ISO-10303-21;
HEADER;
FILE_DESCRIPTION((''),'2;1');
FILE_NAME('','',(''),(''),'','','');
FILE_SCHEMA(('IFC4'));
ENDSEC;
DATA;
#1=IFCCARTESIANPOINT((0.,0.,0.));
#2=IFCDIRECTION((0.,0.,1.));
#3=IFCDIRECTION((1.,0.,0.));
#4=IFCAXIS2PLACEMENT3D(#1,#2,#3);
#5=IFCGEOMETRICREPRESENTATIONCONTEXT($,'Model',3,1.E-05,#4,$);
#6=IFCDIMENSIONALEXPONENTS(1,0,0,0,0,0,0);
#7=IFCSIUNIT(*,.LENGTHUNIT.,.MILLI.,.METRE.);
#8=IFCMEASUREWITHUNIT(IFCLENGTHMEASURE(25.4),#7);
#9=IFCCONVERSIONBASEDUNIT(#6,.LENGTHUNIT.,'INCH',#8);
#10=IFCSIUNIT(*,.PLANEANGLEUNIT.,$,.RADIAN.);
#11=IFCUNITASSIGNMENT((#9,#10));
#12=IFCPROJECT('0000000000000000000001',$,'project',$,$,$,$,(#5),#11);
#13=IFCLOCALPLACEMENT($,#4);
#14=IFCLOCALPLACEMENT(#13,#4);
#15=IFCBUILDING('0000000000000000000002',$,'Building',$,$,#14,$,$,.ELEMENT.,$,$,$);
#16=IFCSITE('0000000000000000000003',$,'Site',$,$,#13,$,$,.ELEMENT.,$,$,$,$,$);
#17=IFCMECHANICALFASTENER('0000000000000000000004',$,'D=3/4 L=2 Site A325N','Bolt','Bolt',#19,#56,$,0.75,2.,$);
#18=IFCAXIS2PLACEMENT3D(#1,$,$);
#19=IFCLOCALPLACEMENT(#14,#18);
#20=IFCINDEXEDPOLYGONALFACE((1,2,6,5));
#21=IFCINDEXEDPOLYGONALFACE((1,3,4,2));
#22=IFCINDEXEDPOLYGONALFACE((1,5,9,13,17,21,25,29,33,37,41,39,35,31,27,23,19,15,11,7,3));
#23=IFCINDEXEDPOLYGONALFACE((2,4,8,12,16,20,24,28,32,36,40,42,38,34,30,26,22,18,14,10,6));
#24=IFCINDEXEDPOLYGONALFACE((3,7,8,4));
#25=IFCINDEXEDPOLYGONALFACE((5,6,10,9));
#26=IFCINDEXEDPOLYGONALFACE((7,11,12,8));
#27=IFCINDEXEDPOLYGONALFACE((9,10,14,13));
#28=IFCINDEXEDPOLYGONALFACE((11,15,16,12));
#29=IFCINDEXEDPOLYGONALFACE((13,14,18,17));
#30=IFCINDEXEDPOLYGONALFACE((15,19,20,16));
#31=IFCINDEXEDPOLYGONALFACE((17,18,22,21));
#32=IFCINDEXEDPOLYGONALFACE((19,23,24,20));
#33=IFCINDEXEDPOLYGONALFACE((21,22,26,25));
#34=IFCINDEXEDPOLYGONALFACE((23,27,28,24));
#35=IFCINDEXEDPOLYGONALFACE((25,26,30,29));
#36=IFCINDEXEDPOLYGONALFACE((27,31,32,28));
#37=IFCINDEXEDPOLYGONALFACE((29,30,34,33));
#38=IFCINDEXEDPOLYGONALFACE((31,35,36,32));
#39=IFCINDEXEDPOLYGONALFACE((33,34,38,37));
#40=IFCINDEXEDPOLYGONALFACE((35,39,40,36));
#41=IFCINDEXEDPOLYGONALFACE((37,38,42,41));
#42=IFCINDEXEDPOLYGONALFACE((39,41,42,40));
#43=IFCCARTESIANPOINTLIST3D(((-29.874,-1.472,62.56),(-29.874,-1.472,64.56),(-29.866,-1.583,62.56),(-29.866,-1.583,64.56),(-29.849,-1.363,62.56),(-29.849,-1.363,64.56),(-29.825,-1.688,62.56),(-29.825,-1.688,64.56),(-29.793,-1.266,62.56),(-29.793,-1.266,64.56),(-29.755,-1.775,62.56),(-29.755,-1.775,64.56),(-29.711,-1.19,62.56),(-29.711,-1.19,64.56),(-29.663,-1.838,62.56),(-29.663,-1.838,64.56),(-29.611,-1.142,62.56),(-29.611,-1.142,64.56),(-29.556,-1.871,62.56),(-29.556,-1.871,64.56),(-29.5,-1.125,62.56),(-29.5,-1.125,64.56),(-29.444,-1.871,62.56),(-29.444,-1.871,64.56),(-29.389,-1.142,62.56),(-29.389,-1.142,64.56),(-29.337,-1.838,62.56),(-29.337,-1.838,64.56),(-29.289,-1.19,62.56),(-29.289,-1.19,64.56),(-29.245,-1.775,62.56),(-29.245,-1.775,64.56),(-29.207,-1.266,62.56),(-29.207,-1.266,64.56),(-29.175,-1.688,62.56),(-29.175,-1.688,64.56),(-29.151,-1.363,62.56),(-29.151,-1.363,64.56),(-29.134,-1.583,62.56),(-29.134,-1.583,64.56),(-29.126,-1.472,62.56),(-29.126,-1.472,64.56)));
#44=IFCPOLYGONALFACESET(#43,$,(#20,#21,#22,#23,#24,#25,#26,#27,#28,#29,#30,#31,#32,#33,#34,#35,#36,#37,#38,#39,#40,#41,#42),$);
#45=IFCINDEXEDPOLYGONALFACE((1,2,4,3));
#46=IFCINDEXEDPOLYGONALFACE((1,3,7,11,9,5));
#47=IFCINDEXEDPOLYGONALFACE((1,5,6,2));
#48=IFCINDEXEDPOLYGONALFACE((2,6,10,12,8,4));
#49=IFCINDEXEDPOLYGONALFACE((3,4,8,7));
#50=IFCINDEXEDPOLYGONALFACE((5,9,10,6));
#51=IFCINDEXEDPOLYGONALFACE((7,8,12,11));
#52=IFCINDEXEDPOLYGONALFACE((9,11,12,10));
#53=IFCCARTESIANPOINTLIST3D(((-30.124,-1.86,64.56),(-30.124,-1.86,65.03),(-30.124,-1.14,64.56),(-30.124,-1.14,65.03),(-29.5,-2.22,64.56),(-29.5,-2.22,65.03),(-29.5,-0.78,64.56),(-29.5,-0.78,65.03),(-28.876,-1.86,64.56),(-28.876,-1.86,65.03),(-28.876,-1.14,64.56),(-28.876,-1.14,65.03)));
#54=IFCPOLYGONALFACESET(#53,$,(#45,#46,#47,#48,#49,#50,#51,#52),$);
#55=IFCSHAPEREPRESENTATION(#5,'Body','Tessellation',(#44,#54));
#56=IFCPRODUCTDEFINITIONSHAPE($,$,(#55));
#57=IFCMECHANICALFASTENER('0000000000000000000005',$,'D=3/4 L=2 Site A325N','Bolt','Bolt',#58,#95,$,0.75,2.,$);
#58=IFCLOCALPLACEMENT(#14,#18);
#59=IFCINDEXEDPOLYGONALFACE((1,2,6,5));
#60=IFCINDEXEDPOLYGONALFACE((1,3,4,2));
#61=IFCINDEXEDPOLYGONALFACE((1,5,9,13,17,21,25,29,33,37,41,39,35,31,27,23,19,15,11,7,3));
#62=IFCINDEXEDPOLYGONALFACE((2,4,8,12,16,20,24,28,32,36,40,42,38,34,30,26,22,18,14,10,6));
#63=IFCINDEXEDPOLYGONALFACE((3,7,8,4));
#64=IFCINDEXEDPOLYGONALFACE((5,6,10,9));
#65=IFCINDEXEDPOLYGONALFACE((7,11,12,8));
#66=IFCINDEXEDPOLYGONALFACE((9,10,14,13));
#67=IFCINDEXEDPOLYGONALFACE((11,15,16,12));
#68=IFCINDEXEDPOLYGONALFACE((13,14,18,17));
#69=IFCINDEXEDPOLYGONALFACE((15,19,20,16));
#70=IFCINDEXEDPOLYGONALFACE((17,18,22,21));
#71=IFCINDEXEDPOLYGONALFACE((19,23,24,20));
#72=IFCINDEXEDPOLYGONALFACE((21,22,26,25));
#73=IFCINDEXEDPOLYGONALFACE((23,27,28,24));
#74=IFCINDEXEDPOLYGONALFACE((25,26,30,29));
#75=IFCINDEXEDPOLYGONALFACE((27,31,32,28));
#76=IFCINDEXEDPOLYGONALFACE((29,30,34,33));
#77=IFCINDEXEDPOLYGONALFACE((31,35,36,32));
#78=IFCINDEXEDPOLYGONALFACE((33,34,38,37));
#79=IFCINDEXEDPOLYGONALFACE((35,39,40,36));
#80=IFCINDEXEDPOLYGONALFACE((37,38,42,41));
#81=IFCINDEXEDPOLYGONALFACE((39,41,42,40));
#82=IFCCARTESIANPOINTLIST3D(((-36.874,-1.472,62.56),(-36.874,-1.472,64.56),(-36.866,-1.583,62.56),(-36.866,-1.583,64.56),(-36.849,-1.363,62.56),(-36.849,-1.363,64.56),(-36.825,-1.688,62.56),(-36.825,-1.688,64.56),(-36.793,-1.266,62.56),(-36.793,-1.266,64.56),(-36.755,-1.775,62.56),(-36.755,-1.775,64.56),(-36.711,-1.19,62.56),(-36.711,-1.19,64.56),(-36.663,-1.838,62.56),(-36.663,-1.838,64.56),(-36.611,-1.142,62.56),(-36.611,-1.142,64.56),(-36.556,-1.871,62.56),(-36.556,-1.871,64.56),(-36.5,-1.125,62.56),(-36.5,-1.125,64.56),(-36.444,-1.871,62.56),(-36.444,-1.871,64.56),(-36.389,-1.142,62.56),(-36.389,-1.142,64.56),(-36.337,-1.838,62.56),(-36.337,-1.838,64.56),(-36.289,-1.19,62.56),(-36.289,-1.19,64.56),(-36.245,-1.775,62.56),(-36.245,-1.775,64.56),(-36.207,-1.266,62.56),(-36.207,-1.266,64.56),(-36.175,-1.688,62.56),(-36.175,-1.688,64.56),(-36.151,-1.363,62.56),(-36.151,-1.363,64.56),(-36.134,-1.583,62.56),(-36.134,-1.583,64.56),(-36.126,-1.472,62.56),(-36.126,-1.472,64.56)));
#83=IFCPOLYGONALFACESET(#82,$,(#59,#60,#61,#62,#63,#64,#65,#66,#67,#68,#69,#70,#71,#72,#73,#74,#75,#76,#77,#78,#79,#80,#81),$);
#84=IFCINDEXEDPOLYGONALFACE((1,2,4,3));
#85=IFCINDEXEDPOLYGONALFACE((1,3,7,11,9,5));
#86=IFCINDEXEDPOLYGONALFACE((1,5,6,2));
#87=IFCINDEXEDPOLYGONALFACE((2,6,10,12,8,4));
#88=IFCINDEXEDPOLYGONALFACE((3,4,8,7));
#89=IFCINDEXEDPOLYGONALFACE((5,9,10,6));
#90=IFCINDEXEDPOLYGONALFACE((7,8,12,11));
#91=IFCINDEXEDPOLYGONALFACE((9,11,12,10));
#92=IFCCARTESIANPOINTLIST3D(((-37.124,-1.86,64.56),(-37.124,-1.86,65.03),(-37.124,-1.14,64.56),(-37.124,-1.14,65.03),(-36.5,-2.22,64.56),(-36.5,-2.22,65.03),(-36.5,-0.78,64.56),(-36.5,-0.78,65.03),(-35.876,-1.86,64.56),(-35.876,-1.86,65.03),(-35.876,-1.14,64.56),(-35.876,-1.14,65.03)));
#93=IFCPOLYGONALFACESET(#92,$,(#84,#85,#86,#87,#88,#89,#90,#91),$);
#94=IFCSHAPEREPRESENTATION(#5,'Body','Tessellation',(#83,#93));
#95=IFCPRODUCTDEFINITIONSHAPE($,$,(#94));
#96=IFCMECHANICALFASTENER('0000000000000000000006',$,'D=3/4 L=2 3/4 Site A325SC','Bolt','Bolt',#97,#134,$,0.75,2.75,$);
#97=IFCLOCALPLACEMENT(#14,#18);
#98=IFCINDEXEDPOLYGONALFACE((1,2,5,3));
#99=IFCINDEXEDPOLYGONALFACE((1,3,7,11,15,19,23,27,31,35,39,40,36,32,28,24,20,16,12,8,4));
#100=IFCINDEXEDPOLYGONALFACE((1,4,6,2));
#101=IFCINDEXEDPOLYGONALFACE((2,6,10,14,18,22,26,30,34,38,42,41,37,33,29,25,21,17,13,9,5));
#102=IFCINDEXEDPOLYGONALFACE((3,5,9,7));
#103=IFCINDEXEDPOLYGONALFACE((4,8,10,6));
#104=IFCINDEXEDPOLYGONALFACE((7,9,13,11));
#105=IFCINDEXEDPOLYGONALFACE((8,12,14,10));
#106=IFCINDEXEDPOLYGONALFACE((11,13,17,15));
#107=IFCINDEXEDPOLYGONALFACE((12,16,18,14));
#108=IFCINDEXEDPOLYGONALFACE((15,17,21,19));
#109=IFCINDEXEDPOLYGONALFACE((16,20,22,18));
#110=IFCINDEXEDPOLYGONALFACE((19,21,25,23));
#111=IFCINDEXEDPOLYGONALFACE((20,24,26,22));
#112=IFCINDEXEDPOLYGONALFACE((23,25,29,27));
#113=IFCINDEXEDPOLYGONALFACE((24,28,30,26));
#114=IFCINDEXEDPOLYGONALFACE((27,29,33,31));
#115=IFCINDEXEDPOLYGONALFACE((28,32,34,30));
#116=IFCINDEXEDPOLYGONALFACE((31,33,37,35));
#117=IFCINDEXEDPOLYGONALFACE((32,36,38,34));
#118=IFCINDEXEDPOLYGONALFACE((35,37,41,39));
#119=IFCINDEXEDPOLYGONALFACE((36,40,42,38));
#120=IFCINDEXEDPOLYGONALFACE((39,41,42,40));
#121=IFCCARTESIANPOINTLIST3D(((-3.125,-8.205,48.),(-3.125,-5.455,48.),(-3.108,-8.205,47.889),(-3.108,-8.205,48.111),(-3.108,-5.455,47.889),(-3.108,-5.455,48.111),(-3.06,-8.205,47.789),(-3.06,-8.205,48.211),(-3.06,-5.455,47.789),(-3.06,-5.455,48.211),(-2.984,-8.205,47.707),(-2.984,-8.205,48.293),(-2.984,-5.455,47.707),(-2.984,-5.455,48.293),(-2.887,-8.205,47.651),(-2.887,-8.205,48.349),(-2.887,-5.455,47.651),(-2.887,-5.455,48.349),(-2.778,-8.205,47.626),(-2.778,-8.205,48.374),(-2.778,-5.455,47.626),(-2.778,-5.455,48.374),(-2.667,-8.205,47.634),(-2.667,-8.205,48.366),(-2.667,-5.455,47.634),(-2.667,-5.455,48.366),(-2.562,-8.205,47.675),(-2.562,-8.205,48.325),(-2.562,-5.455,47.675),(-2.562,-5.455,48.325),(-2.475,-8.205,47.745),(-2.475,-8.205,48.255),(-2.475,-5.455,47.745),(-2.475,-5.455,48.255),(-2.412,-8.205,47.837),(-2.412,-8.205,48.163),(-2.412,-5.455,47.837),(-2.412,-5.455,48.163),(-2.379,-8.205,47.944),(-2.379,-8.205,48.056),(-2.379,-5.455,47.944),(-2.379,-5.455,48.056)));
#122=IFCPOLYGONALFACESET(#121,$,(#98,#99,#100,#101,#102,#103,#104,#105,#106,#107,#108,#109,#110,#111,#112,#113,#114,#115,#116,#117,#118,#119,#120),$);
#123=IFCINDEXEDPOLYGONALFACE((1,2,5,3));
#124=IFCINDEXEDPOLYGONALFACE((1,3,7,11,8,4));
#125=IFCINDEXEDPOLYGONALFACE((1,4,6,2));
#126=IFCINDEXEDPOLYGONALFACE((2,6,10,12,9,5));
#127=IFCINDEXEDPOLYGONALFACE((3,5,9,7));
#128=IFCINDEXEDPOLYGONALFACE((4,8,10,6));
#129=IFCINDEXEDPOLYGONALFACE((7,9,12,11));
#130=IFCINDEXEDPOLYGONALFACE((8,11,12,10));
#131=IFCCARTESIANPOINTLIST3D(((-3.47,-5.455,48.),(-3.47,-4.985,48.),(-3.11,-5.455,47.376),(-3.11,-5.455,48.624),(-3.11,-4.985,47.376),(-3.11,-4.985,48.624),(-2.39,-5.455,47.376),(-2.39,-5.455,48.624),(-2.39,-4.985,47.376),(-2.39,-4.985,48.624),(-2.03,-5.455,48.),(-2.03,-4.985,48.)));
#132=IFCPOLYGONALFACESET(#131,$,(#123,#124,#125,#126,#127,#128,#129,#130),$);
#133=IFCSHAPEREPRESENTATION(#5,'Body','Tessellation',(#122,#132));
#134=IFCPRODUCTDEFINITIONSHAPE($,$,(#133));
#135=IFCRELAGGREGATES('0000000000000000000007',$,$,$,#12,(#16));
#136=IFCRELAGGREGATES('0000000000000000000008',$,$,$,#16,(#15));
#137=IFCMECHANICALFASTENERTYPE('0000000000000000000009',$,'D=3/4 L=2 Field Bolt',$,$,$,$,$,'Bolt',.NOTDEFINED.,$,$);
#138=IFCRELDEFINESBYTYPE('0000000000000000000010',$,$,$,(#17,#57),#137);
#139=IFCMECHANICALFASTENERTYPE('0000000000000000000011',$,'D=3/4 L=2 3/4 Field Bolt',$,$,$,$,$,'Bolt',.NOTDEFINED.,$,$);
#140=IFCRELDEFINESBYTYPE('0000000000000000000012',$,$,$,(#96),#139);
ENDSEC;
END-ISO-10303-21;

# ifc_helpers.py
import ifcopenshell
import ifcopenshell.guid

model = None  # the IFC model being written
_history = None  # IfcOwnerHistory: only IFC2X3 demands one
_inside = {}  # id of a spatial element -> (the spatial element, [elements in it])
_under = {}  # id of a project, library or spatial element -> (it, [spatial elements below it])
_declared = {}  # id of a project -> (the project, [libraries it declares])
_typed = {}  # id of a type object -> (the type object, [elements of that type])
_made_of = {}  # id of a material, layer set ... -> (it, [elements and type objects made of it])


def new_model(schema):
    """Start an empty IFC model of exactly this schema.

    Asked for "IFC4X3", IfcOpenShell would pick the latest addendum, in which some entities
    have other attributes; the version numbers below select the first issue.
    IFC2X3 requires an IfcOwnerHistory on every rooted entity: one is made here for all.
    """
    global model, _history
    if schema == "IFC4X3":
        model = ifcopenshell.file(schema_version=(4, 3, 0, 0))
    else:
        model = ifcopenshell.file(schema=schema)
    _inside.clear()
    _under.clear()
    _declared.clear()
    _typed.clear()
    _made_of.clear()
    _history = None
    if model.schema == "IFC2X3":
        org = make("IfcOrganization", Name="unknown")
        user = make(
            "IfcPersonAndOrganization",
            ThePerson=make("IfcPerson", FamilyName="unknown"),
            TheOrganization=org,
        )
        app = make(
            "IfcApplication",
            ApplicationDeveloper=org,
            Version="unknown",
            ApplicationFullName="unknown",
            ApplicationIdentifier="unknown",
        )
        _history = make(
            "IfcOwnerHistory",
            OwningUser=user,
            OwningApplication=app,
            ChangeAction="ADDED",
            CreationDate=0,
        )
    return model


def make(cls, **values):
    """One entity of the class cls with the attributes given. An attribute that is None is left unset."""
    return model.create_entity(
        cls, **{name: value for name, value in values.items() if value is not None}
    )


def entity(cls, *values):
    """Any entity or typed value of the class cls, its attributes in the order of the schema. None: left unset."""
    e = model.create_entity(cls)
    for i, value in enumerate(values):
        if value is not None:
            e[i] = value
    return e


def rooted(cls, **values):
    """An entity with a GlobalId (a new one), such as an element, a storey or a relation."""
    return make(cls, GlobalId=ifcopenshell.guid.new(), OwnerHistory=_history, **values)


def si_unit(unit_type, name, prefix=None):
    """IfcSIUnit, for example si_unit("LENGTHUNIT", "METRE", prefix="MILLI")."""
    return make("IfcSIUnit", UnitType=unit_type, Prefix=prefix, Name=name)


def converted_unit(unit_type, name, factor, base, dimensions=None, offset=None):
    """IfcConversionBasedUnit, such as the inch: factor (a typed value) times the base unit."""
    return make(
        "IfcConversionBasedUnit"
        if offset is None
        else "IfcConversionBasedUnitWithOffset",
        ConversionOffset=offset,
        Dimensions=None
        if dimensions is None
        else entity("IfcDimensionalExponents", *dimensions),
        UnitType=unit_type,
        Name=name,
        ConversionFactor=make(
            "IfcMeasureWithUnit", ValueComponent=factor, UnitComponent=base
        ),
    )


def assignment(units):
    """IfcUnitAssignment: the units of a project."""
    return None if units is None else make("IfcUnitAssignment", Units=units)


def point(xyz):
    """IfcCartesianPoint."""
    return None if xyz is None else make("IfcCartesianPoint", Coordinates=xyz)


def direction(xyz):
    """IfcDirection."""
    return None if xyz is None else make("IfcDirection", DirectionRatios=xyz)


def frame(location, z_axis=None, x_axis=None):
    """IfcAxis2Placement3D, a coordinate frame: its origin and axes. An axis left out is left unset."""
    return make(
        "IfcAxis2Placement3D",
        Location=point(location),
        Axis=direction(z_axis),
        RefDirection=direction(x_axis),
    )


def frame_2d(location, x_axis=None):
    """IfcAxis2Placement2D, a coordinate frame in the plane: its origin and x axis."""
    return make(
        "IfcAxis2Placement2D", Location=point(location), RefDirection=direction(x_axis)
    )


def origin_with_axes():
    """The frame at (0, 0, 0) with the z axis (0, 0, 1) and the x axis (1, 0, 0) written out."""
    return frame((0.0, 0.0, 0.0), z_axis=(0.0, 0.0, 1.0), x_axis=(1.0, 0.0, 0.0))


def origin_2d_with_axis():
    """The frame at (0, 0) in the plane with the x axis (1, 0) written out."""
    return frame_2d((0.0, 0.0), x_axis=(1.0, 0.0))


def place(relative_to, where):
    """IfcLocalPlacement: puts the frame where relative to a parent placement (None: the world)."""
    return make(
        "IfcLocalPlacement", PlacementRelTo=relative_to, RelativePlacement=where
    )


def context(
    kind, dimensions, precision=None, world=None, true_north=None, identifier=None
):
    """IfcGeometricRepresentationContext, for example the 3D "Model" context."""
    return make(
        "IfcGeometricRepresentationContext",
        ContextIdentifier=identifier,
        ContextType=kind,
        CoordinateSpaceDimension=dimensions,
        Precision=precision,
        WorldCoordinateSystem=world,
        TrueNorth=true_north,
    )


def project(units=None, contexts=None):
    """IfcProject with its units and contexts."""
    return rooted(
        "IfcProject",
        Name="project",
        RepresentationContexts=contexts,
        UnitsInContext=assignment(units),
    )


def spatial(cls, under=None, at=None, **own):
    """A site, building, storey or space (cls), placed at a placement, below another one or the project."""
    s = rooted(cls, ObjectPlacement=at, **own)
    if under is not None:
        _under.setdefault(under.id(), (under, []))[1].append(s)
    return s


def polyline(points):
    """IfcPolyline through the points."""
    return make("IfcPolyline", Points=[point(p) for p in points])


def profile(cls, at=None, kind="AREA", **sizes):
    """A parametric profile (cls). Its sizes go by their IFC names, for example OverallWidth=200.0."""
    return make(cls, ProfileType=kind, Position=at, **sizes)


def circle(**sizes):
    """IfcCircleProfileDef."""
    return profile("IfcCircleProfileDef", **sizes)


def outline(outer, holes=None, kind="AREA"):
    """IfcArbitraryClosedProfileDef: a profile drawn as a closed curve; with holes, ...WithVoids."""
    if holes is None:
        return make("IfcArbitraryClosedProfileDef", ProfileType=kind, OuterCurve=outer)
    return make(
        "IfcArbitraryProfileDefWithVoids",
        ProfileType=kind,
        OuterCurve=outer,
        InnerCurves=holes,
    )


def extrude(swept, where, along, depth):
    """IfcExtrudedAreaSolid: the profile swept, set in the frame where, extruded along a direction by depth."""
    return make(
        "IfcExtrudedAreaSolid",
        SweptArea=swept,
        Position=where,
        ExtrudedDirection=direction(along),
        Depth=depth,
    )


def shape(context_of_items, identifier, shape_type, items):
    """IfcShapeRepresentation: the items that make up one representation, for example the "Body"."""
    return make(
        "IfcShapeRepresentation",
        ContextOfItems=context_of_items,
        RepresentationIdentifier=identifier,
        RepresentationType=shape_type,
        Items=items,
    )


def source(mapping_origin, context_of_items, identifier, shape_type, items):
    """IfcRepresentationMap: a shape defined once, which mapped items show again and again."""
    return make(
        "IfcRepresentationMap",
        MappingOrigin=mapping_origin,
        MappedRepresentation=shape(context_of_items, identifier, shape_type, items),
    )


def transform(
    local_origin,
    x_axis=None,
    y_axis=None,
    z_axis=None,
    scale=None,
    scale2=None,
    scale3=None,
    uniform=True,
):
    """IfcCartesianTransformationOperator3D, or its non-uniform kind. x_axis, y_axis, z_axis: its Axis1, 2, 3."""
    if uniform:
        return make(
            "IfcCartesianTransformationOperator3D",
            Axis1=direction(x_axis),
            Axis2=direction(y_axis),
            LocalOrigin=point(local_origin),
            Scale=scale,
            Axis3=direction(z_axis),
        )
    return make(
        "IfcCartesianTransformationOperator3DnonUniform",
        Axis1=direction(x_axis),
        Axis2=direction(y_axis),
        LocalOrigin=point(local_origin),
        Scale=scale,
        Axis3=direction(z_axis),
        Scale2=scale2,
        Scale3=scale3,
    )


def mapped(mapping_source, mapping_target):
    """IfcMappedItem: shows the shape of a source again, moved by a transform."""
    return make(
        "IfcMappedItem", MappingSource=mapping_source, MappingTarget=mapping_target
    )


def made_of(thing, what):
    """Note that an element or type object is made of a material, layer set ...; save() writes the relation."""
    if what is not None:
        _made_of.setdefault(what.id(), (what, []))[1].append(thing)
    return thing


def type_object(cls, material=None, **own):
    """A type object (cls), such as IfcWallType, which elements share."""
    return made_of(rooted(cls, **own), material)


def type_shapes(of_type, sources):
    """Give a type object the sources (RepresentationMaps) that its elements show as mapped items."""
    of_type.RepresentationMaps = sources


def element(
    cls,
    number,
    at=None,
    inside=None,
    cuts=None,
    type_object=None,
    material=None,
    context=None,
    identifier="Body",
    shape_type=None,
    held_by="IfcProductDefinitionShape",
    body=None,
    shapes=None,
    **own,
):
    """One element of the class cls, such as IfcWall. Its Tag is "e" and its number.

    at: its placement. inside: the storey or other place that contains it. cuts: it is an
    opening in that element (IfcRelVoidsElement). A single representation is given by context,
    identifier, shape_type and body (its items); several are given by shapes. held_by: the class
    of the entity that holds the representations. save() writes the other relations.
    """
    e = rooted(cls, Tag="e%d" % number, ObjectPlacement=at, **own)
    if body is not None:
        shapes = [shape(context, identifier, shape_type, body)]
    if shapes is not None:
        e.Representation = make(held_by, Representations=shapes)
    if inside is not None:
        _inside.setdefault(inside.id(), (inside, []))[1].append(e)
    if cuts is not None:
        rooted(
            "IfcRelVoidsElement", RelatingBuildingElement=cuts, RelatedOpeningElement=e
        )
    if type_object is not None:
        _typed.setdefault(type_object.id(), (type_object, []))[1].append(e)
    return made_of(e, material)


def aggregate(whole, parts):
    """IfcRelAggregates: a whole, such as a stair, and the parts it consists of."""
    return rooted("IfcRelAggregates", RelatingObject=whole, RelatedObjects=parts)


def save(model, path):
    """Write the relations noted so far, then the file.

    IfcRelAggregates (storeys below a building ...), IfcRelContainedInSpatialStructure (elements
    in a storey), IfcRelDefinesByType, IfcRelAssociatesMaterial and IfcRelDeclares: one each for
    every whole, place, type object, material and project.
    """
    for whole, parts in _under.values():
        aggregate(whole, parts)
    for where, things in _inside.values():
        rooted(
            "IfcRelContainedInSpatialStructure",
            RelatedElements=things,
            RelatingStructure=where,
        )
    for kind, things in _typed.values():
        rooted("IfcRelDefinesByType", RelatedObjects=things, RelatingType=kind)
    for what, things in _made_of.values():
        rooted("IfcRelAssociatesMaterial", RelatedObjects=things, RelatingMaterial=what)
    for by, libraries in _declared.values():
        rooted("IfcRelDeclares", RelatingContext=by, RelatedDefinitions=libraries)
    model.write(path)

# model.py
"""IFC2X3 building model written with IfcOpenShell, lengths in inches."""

from ifc_helpers import new_model, entity, si_unit, converted_unit, frame, origin_with_axes, origin_2d_with_axis, place, context, project, spatial, polyline, circle, outline, extrude, source, transform, mapped, type_object, type_shapes, element, save


model = new_model("IFC2X3")

# Units and contexts
model_context = context("Model", 3, precision=1e-05, world=origin_with_axes())
ifc_project = project(units=[converted_unit("LENGTHUNIT", "INCH", entity("IfcLengthMeasure", 25.4), si_unit("LENGTHUNIT", "METRE", prefix="MILLI"), dimensions=[1, 0, 0, 0, 0, 0, 0]), si_unit("PLANEANGLEUNIT", "RADIAN")], contexts=[model_context])

# Site, building
site_placement = place(None, origin_with_axes())
site = spatial("IfcSite", under=ifc_project, at=site_placement, Name="Site", CompositionType="ELEMENT")
building_placement = place(site_placement, origin_with_axes())
building = spatial("IfcBuilding", under=site, at=building_placement, Name="Building", CompositionType="ELEMENT")

# Shared definitions
assembly_1_placement = place(building_placement, frame((-33.0, 0.0, 46.0), z_axis=(-1.0, 0.0, 0.0), x_axis=(0.0, 0.0, 1.0)))

# Shared definitions
assembly_2_placement = place(building_placement, frame((0.0, 0.0, 46.0), z_axis=(0.0, 0.0, 1.0), x_axis=(0.0, -1.0, 0.0)))

# Mechanical fasteners
mechanical_fastener_type_1 = type_object("IfcMechanicalFastenerType", Name="D=3/4 L=2 Field Bolt", ElementType="Bolt")
shared_shape_1 = source(origin_with_axes(), model_context, "Body", "SweptSolid", [
    extrude(circle(Radius=0.375, at=origin_2d_with_axis()), frame((0.0, 0.0, 0.0), z_axis=(1.0, 0.0, 0.0), x_axis=(0.0, 1.0, 0.0)), (0.0, 0.0, 1.0), 2.0),
    extrude(outline(polyline([(-0.72, 0.0), (-0.36, 0.624), (0.36, 0.624), (0.72, 0.0), (0.36, -0.624), (-0.36, -0.624), (-0.72, 0.0)])), frame((0.0, 0.0, 0.0), z_axis=(1.0, 0.0, 0.0), x_axis=(0.0, 1.0, 0.0)), (0.0, 0.0, -1.0), 0.47),
])
type_shapes(mechanical_fastener_type_1, [shared_shape_1])
placement_1 = place(assembly_1_placement, frame((18.56, -1.5, 3.5), z_axis=(0.0, 0.0, -1.0), x_axis=(-1.0, 0.0, 0.0)))
for number, where, z_axis, x_axis, name in (
    (1, (0.0, 0.0, 7.0), (0.0, 0.0, 1.0), (1.0, 0.0, 0.0), "D=3/4 L=2 Site A325N"),
    (2, (0.0, 0.0, 0.0), (0.0, 0.0, 1.0), (1.0, 0.0, 0.0), "D=3/4 L=2 Site A325N"),
):
    element("IfcMechanicalFastener", number, at=place(placement_1, frame(where, z_axis=z_axis, x_axis=x_axis)), type_object=mechanical_fastener_type_1, Name=name, Description="Bolt", ObjectType="Bolt", NominalDiameter=0.75, NominalLength=2.0, context=model_context, shape_type="MappedRepresentation", body=[
        mapped(shared_shape_1, transform((0.0, 0.0, 0.0), scale=1.0)),
    ])
mechanical_fastener_type_2 = type_object("IfcMechanicalFastenerType", Name="D=3/4 L=2 3/4 Field Bolt", ElementType="Bolt")
shared_shape_2 = source(origin_with_axes(), model_context, "Body", "SweptSolid", [
    extrude(circle(Radius=0.375, at=origin_2d_with_axis()), frame((0.0, 0.0, 0.0), z_axis=(1.0, 0.0, 0.0), x_axis=(0.0, 1.0, 0.0)), (0.0, 0.0, 1.0), 2.75),
    extrude(outline(polyline([(-0.72, 0.0), (-0.36, 0.624), (0.36, 0.624), (0.72, 0.0), (0.36, -0.624), (-0.36, -0.624), (-0.72, 0.0)])), frame((0.0, 0.0, 0.0), z_axis=(1.0, 0.0, 0.0), x_axis=(0.0, 1.0, 0.0)), (0.0, 0.0, -1.0), 0.47),
])
type_shapes(mechanical_fastener_type_2, [shared_shape_2])
placement_2 = place(assembly_2_placement, frame((5.455, -2.75, 2.0), z_axis=(0.0, 0.0, -1.0), x_axis=(1.0, 0.0, 0.0)))
mechanical_fastener_1_placement = place(placement_2, origin_with_axes())
element("IfcMechanicalFastener", 3, at=mechanical_fastener_1_placement, type_object=mechanical_fastener_type_2, Name="D=3/4 L=2 3/4 Site A325SC", Description="Bolt", ObjectType="Bolt", NominalDiameter=0.75, NominalLength=2.75, context=model_context, shape_type="MappedRepresentation", body=[
    mapped(shared_shape_2, transform((0.0, 0.0, 0.0), scale=1.0)),
])

save(model, "model.ifc")
